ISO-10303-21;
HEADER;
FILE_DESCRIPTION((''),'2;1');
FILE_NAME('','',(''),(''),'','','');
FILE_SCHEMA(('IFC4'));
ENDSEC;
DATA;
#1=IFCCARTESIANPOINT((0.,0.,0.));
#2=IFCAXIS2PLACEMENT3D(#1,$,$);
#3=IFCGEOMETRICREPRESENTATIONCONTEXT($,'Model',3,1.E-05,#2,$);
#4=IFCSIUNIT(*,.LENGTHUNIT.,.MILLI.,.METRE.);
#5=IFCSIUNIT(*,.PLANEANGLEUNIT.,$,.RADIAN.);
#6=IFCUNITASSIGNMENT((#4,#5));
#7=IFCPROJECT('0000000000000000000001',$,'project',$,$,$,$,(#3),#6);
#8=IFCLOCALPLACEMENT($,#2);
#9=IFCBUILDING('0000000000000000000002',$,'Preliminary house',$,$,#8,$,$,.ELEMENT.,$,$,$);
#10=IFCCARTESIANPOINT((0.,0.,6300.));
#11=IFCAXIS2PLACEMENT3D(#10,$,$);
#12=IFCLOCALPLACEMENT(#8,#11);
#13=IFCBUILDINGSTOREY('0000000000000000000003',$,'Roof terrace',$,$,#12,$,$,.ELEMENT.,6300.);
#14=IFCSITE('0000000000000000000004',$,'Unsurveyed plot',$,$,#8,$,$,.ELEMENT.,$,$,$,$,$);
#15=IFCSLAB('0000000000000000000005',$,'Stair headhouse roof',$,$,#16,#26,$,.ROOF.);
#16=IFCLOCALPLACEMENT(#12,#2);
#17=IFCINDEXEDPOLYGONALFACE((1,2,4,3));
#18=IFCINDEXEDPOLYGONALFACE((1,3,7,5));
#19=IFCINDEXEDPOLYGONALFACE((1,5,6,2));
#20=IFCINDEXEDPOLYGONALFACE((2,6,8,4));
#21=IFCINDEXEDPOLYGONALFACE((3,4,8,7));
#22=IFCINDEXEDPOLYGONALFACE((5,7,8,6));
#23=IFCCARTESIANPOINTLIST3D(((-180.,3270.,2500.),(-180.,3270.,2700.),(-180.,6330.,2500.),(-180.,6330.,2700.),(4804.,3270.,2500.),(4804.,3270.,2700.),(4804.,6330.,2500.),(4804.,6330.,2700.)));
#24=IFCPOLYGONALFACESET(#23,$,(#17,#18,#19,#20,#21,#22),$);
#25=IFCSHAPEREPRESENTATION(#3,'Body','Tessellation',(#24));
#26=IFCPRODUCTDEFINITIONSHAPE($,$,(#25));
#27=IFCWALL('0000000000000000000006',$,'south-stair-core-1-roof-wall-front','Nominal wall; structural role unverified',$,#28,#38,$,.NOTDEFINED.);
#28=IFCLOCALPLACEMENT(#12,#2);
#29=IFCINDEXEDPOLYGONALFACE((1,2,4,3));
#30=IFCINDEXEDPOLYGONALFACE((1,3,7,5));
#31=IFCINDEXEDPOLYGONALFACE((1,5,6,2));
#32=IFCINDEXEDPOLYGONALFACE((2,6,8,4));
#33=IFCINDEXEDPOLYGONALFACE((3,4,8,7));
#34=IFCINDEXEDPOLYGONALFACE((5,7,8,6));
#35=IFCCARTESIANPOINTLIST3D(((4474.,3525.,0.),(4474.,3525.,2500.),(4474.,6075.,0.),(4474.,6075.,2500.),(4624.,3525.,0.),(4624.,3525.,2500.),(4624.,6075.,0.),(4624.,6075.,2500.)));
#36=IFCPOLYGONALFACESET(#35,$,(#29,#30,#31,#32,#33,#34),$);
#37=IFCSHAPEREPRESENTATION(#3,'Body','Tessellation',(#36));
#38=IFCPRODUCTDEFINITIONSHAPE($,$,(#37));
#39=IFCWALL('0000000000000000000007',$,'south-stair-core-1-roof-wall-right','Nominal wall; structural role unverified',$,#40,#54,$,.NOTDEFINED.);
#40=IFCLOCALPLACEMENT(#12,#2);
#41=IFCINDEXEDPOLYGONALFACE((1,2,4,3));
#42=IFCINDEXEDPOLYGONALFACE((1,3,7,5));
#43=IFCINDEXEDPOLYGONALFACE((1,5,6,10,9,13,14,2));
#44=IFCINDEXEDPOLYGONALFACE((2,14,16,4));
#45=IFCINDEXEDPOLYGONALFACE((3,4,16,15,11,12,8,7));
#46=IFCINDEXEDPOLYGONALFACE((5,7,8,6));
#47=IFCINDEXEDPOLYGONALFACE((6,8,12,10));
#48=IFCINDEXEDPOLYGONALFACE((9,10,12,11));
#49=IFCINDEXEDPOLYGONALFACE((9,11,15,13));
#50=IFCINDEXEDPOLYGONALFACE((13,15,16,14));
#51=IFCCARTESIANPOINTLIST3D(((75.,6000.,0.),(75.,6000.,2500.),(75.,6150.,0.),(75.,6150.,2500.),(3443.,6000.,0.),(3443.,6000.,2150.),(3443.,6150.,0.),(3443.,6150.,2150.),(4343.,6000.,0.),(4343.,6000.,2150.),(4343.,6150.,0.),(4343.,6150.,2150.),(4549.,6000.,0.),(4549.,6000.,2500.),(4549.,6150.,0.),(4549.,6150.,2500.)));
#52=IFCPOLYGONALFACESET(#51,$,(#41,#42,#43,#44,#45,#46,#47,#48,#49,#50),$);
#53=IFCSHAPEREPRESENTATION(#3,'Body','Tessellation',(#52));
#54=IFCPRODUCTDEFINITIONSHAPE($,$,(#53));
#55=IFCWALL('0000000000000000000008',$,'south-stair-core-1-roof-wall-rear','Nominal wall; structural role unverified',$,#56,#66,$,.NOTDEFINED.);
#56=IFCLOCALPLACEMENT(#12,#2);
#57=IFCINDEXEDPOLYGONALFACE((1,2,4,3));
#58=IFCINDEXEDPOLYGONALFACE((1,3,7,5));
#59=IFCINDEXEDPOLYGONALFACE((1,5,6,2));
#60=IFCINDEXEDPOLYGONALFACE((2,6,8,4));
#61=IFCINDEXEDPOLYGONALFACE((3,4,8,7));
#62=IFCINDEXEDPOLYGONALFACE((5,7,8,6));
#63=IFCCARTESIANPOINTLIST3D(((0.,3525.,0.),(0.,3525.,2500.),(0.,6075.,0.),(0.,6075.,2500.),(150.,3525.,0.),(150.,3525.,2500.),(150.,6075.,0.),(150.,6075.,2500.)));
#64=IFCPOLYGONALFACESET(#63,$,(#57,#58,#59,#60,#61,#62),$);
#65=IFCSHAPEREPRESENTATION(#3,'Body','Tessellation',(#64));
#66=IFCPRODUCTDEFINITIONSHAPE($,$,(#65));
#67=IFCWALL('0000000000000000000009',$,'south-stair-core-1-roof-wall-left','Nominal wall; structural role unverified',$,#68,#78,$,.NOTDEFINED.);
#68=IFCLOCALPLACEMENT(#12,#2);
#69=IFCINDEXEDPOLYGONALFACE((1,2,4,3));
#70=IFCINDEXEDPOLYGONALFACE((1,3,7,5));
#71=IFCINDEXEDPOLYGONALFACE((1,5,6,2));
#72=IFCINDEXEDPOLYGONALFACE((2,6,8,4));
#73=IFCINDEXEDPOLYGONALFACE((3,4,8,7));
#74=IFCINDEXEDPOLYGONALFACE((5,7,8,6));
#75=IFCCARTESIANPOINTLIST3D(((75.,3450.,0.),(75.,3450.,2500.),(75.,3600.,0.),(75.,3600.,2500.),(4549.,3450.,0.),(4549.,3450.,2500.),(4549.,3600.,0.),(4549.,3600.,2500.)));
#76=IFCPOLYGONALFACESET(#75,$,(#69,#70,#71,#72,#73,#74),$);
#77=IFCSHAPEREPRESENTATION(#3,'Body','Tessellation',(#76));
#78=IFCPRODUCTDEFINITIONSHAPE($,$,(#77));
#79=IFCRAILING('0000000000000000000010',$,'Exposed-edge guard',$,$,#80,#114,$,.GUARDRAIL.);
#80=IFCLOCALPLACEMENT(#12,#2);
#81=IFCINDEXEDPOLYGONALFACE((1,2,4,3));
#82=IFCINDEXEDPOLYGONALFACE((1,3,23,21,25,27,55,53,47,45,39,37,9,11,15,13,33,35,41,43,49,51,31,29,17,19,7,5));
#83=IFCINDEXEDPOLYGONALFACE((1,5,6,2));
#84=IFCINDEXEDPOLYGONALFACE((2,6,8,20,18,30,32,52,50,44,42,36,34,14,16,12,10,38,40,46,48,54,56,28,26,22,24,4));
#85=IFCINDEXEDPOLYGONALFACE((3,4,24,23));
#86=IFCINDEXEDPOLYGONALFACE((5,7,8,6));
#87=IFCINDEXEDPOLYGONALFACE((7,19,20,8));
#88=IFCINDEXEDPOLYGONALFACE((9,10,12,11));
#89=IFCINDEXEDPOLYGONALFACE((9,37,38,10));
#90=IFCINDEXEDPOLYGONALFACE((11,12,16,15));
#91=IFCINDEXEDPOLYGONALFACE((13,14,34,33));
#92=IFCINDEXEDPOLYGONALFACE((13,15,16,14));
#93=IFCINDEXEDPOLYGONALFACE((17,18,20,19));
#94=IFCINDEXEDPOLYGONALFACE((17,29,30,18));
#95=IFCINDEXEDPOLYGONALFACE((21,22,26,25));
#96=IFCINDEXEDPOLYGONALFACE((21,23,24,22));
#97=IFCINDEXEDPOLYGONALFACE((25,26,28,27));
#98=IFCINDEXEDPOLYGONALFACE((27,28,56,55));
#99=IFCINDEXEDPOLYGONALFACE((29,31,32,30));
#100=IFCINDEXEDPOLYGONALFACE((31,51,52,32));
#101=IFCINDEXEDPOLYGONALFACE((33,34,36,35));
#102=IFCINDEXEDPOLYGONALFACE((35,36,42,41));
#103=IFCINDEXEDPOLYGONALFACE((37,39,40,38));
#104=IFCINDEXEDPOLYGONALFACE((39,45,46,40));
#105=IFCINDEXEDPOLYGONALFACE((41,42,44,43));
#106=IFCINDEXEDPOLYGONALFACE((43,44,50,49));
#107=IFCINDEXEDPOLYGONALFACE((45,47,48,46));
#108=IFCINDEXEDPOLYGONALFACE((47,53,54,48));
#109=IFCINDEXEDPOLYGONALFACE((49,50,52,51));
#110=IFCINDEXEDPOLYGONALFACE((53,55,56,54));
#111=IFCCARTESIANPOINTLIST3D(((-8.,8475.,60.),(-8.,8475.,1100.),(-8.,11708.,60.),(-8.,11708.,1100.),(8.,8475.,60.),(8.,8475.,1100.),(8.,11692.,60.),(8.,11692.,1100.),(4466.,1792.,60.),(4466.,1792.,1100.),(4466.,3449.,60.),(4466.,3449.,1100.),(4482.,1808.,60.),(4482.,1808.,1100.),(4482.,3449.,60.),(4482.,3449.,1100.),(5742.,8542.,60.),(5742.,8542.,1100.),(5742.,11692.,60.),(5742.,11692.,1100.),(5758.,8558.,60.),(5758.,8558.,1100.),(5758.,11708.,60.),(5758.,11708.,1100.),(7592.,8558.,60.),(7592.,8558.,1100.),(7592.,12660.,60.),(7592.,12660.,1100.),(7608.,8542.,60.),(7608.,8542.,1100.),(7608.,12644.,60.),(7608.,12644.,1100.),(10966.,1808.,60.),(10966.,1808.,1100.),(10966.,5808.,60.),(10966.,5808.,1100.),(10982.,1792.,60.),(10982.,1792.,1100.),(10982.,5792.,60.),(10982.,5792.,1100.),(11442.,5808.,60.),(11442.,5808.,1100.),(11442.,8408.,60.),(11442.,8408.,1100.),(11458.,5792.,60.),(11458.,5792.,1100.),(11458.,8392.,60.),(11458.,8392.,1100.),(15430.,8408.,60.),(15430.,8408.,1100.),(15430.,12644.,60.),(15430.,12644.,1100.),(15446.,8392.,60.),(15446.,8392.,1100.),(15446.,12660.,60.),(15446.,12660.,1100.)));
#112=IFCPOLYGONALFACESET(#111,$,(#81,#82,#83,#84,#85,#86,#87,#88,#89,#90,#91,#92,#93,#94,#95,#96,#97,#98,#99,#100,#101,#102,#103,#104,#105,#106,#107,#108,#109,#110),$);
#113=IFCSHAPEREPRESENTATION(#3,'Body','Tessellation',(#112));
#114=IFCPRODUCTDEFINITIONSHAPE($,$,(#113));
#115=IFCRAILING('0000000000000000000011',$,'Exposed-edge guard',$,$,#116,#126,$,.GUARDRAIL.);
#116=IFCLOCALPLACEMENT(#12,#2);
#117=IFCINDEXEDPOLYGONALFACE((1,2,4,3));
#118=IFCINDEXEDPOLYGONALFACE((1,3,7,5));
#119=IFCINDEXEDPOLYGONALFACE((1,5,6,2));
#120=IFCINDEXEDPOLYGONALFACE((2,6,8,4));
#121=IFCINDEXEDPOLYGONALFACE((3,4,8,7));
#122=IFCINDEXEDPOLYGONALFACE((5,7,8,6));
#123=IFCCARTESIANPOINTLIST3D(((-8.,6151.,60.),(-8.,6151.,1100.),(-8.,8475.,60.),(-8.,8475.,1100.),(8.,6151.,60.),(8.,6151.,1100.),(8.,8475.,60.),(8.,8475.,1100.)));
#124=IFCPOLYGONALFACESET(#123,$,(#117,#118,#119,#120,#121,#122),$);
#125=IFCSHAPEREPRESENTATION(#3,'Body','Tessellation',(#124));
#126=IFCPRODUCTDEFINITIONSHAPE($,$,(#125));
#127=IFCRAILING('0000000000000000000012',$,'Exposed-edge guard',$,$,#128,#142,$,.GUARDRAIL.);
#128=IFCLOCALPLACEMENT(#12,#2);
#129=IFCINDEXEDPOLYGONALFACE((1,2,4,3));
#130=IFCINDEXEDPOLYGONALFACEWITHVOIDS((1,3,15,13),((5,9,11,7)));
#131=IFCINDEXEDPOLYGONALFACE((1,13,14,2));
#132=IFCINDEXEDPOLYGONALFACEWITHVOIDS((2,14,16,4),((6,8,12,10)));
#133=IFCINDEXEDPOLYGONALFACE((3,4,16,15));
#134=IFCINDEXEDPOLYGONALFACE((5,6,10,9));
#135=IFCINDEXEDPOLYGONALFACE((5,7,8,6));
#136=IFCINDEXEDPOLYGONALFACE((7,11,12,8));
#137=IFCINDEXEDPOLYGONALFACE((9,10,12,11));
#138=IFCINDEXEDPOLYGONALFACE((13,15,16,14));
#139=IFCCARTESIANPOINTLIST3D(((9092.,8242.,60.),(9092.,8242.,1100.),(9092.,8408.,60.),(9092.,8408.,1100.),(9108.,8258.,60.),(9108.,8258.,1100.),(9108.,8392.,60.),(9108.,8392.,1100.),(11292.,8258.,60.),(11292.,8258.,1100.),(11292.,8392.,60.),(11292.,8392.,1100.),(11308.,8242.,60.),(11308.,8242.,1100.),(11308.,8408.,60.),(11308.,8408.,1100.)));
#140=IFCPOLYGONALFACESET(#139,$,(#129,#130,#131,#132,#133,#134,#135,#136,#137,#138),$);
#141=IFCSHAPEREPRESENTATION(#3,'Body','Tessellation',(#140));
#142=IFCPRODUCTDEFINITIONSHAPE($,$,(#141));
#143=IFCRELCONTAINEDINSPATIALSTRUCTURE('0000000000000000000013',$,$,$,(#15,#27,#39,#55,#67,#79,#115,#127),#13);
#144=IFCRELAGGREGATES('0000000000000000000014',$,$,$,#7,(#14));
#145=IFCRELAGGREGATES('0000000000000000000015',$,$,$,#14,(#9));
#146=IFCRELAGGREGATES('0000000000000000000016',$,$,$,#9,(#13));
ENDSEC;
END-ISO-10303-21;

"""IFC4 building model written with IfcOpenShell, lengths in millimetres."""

from ifc_helpers import new_model, si_unit, frame, origin, place, context, project, spatial, polyline, outline, extrude, element, save


model = new_model("IFC4")

# Units and contexts
model_context = context("Model", 3, precision=1e-05, world=origin())
ifc_project = project(units=[si_unit("LENGTHUNIT", "METRE", prefix="MILLI"), si_unit("PLANEANGLEUNIT", "RADIAN")], contexts=[model_context])

# Site, building, storey
placement_1 = place(None, origin())
site = spatial("IfcSite", under=ifc_project, at=placement_1, Name="Unsurveyed plot", CompositionType="ELEMENT")
building = spatial("IfcBuilding", under=site, at=placement_1, Name="Preliminary house", CompositionType="ELEMENT")
placement_2 = place(placement_1, frame((0.0, 0.0, 6300.0)))
storey = spatial("IfcBuildingStorey", under=building, at=placement_2, Name="Roof terrace", CompositionType="ELEMENT", Elevation=6300.0)

# Slab
element("IfcSlab", 1, at=placement_2, inside=storey, Name="Stair headhouse roof", PredefinedType="ROOF", context=model_context, shape_type="SweptSolid", body=[
    extrude(outline(polyline([(4804.0, 3270.0), (-180.0, 3270.0), (-180.0, 6330.0), (4804.0, 6330.0), (4804.0, 3270.0)])), frame((0.0, 0.0, 2500.0)), (0.0, 0.0, 1.0), 200.0),
])

# Wall
element("IfcWall", 2, at=placement_2, inside=storey, Name="south-stair-core-1-roof-wall-front", Description="Nominal wall; structural role unverified", PredefinedType="NOTDEFINED", context=model_context, shape_type="SweptSolid", body=[
    extrude(outline(polyline([(4474.0, 6075.0), (4624.0, 6075.0), (4624.0, 3525.0), (4474.0, 3525.0), (4474.0, 6075.0)])), origin(), (0.0, 0.0, 1.0), 2500.0),
])

# Wall, opening
wall_1 = element("IfcWall", 3, at=placement_2, inside=storey, Name="south-stair-core-1-roof-wall-right", Description="Nominal wall; structural role unverified", PredefinedType="NOTDEFINED", context=model_context, shape_type="SweptSolid", body=[
    extrude(outline(polyline([(75.0, 6000.0), (75.0, 6150.0), (4549.0, 6150.0), (4549.0, 6000.0), (75.0, 6000.0)])), origin(), (0.0, 0.0, 1.0), 2500.0),
])
element("IfcOpeningElement", 4, at=placement_2, cuts=wall_1, PredefinedType="OPENING", context=model_context, shape_type="SweptSolid", body=[
    extrude(outline(polyline([(4343.0, 6525.0), (3443.0, 6525.0), (3443.0, 5625.0), (4343.0, 5625.0), (4343.0, 6525.0)])), origin(), (0.0, 0.0, 1.0), 2150.0),
])

# Walls
element("IfcWall", 5, at=placement_2, inside=storey, Name="south-stair-core-1-roof-wall-rear", Description="Nominal wall; structural role unverified", PredefinedType="NOTDEFINED", context=model_context, shape_type="SweptSolid", body=[
    extrude(outline(polyline([(0.0, 6075.0), (150.0, 6075.0), (150.0, 3525.0), (0.0, 3525.0), (0.0, 6075.0)])), origin(), (0.0, 0.0, 1.0), 2500.0),
])
element("IfcWall", 6, at=placement_2, inside=storey, Name="south-stair-core-1-roof-wall-left", Description="Nominal wall; structural role unverified", PredefinedType="NOTDEFINED", context=model_context, shape_type="SweptSolid", body=[
    extrude(outline(polyline([(75.0, 3450.0), (75.0, 3600.0), (4549.0, 3600.0), (4549.0, 3450.0), (75.0, 3450.0)])), origin(), (0.0, 0.0, 1.0), 2500.0),
])

# Railings
element("IfcRailing", 7, at=placement_2, inside=storey, Name="Exposed-edge guard", PredefinedType="GUARDRAIL", context=model_context, shape_type="SweptSolid", body=[
    extrude(outline(polyline([(-8.0, 11708.0), (5758.0, 11708.0), (5758.0, 8558.0), (7592.0, 8558.0), (7592.0, 12660.0), (15446.0, 12660.0), (15446.0, 8392.0), (11458.0, 8392.0), (11458.0, 5792.0), (10982.0, 5792.0), (10982.0, 1792.0), (4466.0, 1792.0), (4466.0, 3449.0), (4482.0, 3449.0), (4482.0, 1808.0), (10966.0, 1808.0), (10966.0, 5808.0), (11442.0, 5808.0), (11442.0, 8408.0), (15430.0, 8408.0), (15430.0, 12644.0), (7608.0, 12644.0), (7608.0, 8542.0), (5742.0, 8542.0), (5742.0, 11692.0), (8.0, 11692.0), (8.0, 8475.0), (-8.0, 8475.0), (-8.0, 11708.0)])), frame((0.0, 0.0, 60.0)), (0.0, 0.0, 1.0), 1040.0),
])
element("IfcRailing", 8, at=placement_2, inside=storey, Name="Exposed-edge guard", PredefinedType="GUARDRAIL", context=model_context, shape_type="SweptSolid", body=[
    extrude(outline(polyline([(-8.0, 8475.0), (8.0, 8475.0), (8.0, 6151.0), (-8.0, 6151.0), (-8.0, 8475.0)])), frame((0.0, 0.0, 60.0)), (0.0, 0.0, 1.0), 1040.0),
])
element("IfcRailing", 9, at=placement_2, inside=storey, Name="Exposed-edge guard", PredefinedType="GUARDRAIL", context=model_context, shape_type="SweptSolid", body=[
    extrude(outline(polyline([(11308.0, 8242.0), (9092.0, 8242.0), (9092.0, 8408.0), (11308.0, 8408.0), (11308.0, 8242.0)]), holes=[polyline([(11292.0, 8258.0), (11292.0, 8392.0), (9108.0, 8392.0), (9108.0, 8258.0), (11292.0, 8258.0)])]), frame((0.0, 0.0, 60.0)), (0.0, 0.0, 1.0), 1040.0),
])

save(model, "model.ifc")
